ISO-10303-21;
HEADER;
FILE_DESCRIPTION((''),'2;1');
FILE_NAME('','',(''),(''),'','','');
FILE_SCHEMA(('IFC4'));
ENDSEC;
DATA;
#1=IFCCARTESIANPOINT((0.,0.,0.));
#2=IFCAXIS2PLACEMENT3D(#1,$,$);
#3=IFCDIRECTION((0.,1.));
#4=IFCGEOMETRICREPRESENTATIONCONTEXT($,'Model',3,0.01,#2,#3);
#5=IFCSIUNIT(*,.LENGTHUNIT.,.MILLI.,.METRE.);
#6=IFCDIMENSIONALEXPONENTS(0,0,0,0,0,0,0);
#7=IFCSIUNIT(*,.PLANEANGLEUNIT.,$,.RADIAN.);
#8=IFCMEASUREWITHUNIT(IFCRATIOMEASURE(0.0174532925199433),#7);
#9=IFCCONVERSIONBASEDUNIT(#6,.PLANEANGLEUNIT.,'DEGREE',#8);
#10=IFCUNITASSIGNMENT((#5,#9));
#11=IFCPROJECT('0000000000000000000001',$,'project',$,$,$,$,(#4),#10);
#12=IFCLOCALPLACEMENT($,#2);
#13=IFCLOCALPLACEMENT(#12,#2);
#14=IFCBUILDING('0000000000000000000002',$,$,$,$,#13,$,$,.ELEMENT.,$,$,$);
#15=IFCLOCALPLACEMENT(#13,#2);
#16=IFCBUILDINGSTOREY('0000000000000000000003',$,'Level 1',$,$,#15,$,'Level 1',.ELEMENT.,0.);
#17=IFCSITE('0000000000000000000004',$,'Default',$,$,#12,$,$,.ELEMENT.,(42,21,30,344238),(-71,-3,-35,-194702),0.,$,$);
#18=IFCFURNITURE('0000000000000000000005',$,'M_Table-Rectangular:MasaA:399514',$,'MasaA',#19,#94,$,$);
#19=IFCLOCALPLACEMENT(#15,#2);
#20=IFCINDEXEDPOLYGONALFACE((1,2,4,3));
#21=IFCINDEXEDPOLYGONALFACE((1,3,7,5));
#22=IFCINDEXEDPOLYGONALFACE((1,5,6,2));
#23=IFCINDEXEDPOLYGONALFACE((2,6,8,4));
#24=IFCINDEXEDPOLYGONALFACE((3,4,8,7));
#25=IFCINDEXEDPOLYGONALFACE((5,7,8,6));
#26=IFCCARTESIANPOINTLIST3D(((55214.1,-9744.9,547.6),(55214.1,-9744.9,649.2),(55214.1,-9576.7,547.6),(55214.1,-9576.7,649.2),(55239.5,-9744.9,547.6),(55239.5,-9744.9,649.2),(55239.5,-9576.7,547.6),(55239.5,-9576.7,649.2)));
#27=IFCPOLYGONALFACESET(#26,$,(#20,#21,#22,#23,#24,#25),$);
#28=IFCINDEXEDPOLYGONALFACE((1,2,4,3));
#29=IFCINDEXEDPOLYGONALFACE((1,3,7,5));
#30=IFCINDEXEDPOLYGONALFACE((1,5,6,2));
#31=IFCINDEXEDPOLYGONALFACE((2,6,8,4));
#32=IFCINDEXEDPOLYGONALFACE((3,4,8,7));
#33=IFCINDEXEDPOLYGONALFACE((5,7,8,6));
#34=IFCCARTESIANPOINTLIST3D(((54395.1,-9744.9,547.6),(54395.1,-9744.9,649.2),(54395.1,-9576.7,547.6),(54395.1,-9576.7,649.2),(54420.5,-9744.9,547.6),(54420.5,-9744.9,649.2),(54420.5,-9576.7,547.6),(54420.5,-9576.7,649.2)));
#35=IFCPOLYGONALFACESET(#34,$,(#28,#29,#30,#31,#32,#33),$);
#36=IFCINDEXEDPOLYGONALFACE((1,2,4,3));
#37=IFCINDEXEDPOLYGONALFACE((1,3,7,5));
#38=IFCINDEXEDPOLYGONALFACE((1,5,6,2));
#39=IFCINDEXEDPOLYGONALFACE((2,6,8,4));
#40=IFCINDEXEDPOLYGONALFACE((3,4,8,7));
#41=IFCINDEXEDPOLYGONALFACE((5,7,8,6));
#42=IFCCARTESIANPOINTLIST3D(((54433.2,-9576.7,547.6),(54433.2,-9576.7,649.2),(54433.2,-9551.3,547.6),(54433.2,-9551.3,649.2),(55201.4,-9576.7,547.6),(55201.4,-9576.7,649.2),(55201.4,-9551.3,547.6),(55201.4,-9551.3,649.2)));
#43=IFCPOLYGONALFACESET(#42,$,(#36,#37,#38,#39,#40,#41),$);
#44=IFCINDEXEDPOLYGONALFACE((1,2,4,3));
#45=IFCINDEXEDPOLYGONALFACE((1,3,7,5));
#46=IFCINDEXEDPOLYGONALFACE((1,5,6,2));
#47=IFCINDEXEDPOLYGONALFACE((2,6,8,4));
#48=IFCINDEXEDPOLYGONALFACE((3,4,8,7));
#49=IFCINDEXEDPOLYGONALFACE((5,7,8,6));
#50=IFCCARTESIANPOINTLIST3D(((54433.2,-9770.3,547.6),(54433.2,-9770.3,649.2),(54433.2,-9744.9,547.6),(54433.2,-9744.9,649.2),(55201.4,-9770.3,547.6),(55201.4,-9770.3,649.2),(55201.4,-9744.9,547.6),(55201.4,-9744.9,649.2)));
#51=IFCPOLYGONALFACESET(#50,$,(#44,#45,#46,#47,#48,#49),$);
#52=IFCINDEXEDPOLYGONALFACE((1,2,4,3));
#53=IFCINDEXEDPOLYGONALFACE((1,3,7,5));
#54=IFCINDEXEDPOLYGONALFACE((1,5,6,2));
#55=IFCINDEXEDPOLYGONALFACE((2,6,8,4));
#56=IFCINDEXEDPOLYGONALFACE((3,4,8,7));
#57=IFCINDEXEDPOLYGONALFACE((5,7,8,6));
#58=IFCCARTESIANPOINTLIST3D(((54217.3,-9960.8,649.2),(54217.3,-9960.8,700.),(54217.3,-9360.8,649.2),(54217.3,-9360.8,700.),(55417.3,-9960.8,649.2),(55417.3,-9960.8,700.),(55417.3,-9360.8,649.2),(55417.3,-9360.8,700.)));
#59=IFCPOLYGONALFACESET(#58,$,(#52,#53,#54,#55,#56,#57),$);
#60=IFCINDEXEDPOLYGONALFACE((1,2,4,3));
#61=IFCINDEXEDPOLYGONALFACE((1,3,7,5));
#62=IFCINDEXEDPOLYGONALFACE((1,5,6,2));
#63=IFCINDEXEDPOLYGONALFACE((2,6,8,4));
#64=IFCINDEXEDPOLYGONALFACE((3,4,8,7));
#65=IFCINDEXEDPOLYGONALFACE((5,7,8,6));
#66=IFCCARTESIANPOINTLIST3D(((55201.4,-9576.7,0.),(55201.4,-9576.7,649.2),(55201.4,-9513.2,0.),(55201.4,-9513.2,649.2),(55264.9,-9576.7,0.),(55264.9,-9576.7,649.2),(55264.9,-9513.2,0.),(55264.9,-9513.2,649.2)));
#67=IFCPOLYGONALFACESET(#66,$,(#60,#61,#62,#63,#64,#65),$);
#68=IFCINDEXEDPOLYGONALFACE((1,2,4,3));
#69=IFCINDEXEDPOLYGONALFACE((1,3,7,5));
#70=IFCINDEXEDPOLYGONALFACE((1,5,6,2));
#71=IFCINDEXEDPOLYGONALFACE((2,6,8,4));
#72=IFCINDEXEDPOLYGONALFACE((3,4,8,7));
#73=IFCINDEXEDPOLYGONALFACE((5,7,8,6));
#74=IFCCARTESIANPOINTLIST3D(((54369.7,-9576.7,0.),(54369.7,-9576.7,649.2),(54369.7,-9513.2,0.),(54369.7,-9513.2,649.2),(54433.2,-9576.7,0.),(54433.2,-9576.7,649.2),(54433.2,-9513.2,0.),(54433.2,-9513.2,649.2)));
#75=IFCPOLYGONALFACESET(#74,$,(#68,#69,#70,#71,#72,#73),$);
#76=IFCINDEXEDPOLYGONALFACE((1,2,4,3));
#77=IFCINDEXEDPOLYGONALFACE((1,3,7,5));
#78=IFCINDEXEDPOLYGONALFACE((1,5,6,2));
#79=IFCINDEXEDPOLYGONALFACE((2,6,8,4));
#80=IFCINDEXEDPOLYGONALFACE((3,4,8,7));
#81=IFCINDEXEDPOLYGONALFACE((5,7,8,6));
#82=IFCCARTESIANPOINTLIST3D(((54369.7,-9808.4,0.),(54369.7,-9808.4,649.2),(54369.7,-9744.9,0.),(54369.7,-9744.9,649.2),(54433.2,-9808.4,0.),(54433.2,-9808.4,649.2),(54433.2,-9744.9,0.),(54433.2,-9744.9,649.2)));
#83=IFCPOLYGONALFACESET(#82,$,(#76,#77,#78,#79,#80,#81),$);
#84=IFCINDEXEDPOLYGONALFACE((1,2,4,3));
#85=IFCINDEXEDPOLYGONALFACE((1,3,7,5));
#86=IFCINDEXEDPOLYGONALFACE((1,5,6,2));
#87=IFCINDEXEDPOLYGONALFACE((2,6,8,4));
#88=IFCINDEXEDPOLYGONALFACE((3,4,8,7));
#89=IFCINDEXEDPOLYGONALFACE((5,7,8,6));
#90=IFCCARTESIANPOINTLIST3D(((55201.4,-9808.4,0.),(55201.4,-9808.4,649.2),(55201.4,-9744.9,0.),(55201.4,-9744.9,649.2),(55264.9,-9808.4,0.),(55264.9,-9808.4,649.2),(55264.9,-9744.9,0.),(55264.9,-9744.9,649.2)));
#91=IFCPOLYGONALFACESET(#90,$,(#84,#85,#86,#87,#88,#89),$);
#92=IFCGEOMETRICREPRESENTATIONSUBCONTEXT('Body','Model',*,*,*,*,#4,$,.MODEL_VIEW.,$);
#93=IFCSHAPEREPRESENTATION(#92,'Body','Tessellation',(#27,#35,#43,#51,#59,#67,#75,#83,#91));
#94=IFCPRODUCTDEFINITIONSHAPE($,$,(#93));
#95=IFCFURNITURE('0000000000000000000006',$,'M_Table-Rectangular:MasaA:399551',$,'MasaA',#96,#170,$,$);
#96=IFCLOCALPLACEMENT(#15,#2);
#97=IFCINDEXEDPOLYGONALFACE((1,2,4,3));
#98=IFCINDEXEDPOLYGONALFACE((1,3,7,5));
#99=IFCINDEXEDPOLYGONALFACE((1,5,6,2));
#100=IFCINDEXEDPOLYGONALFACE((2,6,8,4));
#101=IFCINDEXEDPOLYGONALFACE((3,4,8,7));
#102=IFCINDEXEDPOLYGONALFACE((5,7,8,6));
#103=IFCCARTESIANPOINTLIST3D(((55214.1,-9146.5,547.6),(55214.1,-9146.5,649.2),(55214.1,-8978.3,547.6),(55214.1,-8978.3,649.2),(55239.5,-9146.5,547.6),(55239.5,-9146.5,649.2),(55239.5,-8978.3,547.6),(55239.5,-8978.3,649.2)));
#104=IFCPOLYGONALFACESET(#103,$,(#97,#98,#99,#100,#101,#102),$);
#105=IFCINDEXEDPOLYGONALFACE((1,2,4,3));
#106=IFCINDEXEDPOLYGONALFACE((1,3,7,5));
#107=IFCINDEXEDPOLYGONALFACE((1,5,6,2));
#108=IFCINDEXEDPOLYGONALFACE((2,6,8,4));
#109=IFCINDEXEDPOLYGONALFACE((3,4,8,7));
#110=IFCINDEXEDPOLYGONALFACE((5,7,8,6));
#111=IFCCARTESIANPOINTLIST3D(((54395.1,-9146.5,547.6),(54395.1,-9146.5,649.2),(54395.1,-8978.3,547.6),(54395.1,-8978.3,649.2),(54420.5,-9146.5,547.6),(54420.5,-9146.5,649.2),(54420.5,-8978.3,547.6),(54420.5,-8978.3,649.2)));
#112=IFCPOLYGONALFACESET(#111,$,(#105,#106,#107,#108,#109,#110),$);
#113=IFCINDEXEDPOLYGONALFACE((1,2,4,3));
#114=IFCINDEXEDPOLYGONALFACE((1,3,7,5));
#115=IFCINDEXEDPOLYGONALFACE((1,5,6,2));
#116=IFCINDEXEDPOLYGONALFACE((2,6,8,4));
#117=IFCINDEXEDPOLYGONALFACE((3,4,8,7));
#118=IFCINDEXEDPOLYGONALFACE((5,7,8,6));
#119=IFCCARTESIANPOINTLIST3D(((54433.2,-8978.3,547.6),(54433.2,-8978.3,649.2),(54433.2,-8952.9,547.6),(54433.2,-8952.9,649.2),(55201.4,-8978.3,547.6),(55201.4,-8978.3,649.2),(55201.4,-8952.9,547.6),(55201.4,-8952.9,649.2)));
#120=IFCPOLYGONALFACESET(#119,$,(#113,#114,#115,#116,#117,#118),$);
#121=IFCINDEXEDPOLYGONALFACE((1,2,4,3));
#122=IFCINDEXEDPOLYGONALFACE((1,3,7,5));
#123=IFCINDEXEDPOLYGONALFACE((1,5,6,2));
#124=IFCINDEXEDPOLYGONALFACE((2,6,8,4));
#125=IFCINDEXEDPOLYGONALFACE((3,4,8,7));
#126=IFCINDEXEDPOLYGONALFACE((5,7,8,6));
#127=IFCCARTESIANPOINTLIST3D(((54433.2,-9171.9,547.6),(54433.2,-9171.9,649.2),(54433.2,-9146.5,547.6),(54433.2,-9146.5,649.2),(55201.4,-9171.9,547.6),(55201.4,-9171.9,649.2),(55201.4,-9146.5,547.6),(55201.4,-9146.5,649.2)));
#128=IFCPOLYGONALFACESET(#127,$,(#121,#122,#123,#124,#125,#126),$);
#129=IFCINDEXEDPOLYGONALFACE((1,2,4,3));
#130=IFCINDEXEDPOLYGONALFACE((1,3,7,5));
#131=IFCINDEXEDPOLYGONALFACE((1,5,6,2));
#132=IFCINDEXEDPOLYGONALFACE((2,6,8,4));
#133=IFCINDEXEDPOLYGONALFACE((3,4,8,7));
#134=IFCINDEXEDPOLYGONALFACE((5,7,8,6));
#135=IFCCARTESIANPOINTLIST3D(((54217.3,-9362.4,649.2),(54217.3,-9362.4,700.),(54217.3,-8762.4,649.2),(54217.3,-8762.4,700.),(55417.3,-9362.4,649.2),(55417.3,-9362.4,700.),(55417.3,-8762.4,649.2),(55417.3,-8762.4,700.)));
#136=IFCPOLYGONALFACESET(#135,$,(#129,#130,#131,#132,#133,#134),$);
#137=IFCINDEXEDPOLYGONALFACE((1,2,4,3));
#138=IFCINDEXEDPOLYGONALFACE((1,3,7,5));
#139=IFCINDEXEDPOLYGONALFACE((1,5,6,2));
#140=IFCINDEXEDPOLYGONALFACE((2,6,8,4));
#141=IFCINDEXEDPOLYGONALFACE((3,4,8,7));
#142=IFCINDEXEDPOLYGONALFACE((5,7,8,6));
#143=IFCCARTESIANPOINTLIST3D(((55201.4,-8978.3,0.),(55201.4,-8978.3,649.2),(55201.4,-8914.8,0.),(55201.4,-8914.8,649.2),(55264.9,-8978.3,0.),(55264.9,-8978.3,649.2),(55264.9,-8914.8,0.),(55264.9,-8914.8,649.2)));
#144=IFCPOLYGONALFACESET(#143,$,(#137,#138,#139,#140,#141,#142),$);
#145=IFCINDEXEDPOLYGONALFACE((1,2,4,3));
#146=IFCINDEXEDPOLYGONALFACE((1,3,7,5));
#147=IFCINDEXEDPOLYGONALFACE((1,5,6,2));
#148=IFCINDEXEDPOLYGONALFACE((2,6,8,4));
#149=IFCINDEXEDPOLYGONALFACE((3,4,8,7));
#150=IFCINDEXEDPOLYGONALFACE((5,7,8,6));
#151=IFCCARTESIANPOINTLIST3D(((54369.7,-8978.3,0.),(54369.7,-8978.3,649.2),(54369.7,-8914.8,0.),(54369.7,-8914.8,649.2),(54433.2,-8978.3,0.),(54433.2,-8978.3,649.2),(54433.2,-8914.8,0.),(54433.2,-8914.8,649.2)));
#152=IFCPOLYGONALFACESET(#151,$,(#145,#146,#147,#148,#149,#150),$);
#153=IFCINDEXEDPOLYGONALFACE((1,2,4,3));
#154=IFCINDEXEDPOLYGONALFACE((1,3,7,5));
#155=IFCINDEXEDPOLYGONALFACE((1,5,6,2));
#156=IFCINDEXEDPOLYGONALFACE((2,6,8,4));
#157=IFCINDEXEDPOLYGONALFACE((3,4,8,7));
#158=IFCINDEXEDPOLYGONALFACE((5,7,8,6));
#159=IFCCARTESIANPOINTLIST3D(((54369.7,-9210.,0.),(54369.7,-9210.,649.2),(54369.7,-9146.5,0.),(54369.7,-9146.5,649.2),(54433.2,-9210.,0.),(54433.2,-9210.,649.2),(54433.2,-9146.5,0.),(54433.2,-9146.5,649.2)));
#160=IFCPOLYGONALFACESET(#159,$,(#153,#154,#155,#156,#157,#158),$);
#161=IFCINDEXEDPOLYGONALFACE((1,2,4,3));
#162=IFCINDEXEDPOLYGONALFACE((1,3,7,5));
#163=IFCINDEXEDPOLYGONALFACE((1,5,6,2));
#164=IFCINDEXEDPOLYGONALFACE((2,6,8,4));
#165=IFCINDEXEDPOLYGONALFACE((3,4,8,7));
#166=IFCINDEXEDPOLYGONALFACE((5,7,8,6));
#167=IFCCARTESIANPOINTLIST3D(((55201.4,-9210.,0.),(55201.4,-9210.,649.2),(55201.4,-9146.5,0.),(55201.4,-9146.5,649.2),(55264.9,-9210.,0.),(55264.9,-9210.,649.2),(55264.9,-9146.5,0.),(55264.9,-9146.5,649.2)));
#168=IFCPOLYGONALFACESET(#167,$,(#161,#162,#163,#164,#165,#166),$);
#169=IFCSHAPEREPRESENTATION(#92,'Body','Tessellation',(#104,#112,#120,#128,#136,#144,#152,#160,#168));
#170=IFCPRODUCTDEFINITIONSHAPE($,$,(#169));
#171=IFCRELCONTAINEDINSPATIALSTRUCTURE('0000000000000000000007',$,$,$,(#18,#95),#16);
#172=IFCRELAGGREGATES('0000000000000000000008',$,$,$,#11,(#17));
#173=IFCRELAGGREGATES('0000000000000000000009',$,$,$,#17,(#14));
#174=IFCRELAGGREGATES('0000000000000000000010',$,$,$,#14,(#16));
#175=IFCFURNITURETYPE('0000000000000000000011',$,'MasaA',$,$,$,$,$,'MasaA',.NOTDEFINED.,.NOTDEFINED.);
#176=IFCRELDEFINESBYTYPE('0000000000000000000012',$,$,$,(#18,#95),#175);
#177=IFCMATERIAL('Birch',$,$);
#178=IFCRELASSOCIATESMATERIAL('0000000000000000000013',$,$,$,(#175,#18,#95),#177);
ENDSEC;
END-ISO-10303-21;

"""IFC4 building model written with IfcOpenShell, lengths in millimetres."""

from ifc_helpers import new_model, entity, si_unit, converted_unit, direction, frame, frame_2d, origin, origin_2d_with_axis, place, context, subcontext, project, spatial, rectangle, extrude, source, transform, mapped, material, type_object, type_shapes, element, save


model = new_model("IFC4")

# Units and contexts
model_context = context("Model", 3, precision=0.01, world=origin(), true_north=direction((0.0, 1.0)))
body_context = subcontext(model_context, "Body", "Model", "MODEL_VIEW")
ifc_project = project(units=[si_unit("LENGTHUNIT", "METRE", prefix="MILLI"), converted_unit("PLANEANGLEUNIT", "DEGREE", entity("IfcRatioMeasure", 0.0174532925199433), si_unit("PLANEANGLEUNIT", "RADIAN"), dimensions=[0, 0, 0, 0, 0, 0, 0])], contexts=[model_context])

# Site, building, storey
site_placement = place(None, origin())
site = spatial("IfcSite", under=ifc_project, at=site_placement, Name="Default", CompositionType="ELEMENT", RefLatitude=(42, 21, 30, 344238), RefLongitude=(-71, -3, -35, -194702), RefElevation=0.0)
building_placement = place(site_placement, origin())
building = spatial("IfcBuilding", under=site, at=building_placement, CompositionType="ELEMENT")
storey_placement = place(building_placement, origin())
storey = spatial("IfcBuildingStorey", under=building, at=storey_placement, Name="Level 1", LongName="Level 1", CompositionType="ELEMENT", Elevation=0.0)

# Furniture
ifc_material_1 = material(Name="Birch")
furniture_type_1 = type_object("IfcFurnitureType", Name="MasaA", ElementType="MasaA", AssemblyPlace="NOTDEFINED", PredefinedType="NOTDEFINED", material=ifc_material_1)
shared_shape_1 = source(origin(), body_context, "Body", "SweptSolid", [
    extrude(rectangle(XDim=25.4, YDim=168.2, at=origin_2d_with_axis()), frame((409.5, 0.0, 547.6)), (0.0, 0.0, 1.0), 101.6),
    extrude(rectangle(XDim=168.2, YDim=25.4, at=origin_2d_with_axis()), frame((-409.5, 0.0, 547.6), z_axis=(0.0, 0.0, 1.0), x_axis=(0.0, 1.0, 0.0)), (0.0, 0.0, 1.0), 101.6),
    extrude(rectangle(XDim=768.2, YDim=25.4, at=frame_2d((0.0, 0.0), x_axis=(1.0, 0.0))), frame((0.0, 96.8, 547.6), z_axis=(0.0, 0.0, 1.0), x_axis=(-1.0, 0.0, 0.0)), (0.0, 0.0, 1.0), 101.6),
    extrude(rectangle(XDim=25.4, YDim=768.2, at=origin_2d_with_axis()), frame((0.0, -96.8, 547.6), z_axis=(0.0, 0.0, 1.0), x_axis=(0.0, 1.0, 0.0)), (0.0, 0.0, 1.0), 101.6),
    extrude(rectangle(XDim=1200.0, YDim=600.0, at=origin_2d_with_axis()), frame((0.0, 0.0, 649.2), z_axis=(0.0, 0.0, 1.0), x_axis=(-1.0, 0.0, 0.0)), (0.0, 0.0, 1.0), 50.8),
    extrude(rectangle(XDim=63.5, YDim=63.5, at=origin_2d_with_axis()), frame((415.9, 115.9, 0.0), z_axis=(0.0, 0.0, 1.0), x_axis=(0.0, -1.0, 0.0)), (0.0, 0.0, 1.0), 649.2),
    extrude(rectangle(XDim=63.5, YDim=63.5, at=frame_2d((0.0, 0.0), x_axis=(1.0, 0.0))), frame((-415.9, 115.9, 0.0), z_axis=(0.0, 0.0, 1.0), x_axis=(-1.0, 0.0, 0.0)), (0.0, 0.0, 1.0), 649.2),
    extrude(rectangle(XDim=63.5, YDim=63.5, at=origin_2d_with_axis()), frame((-415.9, -115.9, 0.0), z_axis=(0.0, 0.0, 1.0), x_axis=(0.0, 1.0, 0.0)), (0.0, 0.0, 1.0), 649.2),
    extrude(rectangle(XDim=63.5, YDim=63.5, at=origin_2d_with_axis()), frame((415.9, -115.9, 0.0)), (0.0, 0.0, 1.0), 649.2),
])
type_shapes(furniture_type_1, [shared_shape_1])
for number, where, name in (
    (1, (54817.3, -9660.8, 0.0), "M_Table-Rectangular:MasaA:399514"),
    (2, (54817.3, -9062.4, 0.0), "M_Table-Rectangular:MasaA:399551"),
):
    element("IfcFurniture", number, at=place(storey_placement, frame(where)), inside=storey, type_object=furniture_type_1, material=ifc_material_1, Name=name, ObjectType="MasaA", context=body_context, shape_type="MappedRepresentation", body=[
        mapped(shared_shape_1, transform((0.0, 0.0, 0.0), scale=1.0)),
    ])

save(model, "model.ifc")
